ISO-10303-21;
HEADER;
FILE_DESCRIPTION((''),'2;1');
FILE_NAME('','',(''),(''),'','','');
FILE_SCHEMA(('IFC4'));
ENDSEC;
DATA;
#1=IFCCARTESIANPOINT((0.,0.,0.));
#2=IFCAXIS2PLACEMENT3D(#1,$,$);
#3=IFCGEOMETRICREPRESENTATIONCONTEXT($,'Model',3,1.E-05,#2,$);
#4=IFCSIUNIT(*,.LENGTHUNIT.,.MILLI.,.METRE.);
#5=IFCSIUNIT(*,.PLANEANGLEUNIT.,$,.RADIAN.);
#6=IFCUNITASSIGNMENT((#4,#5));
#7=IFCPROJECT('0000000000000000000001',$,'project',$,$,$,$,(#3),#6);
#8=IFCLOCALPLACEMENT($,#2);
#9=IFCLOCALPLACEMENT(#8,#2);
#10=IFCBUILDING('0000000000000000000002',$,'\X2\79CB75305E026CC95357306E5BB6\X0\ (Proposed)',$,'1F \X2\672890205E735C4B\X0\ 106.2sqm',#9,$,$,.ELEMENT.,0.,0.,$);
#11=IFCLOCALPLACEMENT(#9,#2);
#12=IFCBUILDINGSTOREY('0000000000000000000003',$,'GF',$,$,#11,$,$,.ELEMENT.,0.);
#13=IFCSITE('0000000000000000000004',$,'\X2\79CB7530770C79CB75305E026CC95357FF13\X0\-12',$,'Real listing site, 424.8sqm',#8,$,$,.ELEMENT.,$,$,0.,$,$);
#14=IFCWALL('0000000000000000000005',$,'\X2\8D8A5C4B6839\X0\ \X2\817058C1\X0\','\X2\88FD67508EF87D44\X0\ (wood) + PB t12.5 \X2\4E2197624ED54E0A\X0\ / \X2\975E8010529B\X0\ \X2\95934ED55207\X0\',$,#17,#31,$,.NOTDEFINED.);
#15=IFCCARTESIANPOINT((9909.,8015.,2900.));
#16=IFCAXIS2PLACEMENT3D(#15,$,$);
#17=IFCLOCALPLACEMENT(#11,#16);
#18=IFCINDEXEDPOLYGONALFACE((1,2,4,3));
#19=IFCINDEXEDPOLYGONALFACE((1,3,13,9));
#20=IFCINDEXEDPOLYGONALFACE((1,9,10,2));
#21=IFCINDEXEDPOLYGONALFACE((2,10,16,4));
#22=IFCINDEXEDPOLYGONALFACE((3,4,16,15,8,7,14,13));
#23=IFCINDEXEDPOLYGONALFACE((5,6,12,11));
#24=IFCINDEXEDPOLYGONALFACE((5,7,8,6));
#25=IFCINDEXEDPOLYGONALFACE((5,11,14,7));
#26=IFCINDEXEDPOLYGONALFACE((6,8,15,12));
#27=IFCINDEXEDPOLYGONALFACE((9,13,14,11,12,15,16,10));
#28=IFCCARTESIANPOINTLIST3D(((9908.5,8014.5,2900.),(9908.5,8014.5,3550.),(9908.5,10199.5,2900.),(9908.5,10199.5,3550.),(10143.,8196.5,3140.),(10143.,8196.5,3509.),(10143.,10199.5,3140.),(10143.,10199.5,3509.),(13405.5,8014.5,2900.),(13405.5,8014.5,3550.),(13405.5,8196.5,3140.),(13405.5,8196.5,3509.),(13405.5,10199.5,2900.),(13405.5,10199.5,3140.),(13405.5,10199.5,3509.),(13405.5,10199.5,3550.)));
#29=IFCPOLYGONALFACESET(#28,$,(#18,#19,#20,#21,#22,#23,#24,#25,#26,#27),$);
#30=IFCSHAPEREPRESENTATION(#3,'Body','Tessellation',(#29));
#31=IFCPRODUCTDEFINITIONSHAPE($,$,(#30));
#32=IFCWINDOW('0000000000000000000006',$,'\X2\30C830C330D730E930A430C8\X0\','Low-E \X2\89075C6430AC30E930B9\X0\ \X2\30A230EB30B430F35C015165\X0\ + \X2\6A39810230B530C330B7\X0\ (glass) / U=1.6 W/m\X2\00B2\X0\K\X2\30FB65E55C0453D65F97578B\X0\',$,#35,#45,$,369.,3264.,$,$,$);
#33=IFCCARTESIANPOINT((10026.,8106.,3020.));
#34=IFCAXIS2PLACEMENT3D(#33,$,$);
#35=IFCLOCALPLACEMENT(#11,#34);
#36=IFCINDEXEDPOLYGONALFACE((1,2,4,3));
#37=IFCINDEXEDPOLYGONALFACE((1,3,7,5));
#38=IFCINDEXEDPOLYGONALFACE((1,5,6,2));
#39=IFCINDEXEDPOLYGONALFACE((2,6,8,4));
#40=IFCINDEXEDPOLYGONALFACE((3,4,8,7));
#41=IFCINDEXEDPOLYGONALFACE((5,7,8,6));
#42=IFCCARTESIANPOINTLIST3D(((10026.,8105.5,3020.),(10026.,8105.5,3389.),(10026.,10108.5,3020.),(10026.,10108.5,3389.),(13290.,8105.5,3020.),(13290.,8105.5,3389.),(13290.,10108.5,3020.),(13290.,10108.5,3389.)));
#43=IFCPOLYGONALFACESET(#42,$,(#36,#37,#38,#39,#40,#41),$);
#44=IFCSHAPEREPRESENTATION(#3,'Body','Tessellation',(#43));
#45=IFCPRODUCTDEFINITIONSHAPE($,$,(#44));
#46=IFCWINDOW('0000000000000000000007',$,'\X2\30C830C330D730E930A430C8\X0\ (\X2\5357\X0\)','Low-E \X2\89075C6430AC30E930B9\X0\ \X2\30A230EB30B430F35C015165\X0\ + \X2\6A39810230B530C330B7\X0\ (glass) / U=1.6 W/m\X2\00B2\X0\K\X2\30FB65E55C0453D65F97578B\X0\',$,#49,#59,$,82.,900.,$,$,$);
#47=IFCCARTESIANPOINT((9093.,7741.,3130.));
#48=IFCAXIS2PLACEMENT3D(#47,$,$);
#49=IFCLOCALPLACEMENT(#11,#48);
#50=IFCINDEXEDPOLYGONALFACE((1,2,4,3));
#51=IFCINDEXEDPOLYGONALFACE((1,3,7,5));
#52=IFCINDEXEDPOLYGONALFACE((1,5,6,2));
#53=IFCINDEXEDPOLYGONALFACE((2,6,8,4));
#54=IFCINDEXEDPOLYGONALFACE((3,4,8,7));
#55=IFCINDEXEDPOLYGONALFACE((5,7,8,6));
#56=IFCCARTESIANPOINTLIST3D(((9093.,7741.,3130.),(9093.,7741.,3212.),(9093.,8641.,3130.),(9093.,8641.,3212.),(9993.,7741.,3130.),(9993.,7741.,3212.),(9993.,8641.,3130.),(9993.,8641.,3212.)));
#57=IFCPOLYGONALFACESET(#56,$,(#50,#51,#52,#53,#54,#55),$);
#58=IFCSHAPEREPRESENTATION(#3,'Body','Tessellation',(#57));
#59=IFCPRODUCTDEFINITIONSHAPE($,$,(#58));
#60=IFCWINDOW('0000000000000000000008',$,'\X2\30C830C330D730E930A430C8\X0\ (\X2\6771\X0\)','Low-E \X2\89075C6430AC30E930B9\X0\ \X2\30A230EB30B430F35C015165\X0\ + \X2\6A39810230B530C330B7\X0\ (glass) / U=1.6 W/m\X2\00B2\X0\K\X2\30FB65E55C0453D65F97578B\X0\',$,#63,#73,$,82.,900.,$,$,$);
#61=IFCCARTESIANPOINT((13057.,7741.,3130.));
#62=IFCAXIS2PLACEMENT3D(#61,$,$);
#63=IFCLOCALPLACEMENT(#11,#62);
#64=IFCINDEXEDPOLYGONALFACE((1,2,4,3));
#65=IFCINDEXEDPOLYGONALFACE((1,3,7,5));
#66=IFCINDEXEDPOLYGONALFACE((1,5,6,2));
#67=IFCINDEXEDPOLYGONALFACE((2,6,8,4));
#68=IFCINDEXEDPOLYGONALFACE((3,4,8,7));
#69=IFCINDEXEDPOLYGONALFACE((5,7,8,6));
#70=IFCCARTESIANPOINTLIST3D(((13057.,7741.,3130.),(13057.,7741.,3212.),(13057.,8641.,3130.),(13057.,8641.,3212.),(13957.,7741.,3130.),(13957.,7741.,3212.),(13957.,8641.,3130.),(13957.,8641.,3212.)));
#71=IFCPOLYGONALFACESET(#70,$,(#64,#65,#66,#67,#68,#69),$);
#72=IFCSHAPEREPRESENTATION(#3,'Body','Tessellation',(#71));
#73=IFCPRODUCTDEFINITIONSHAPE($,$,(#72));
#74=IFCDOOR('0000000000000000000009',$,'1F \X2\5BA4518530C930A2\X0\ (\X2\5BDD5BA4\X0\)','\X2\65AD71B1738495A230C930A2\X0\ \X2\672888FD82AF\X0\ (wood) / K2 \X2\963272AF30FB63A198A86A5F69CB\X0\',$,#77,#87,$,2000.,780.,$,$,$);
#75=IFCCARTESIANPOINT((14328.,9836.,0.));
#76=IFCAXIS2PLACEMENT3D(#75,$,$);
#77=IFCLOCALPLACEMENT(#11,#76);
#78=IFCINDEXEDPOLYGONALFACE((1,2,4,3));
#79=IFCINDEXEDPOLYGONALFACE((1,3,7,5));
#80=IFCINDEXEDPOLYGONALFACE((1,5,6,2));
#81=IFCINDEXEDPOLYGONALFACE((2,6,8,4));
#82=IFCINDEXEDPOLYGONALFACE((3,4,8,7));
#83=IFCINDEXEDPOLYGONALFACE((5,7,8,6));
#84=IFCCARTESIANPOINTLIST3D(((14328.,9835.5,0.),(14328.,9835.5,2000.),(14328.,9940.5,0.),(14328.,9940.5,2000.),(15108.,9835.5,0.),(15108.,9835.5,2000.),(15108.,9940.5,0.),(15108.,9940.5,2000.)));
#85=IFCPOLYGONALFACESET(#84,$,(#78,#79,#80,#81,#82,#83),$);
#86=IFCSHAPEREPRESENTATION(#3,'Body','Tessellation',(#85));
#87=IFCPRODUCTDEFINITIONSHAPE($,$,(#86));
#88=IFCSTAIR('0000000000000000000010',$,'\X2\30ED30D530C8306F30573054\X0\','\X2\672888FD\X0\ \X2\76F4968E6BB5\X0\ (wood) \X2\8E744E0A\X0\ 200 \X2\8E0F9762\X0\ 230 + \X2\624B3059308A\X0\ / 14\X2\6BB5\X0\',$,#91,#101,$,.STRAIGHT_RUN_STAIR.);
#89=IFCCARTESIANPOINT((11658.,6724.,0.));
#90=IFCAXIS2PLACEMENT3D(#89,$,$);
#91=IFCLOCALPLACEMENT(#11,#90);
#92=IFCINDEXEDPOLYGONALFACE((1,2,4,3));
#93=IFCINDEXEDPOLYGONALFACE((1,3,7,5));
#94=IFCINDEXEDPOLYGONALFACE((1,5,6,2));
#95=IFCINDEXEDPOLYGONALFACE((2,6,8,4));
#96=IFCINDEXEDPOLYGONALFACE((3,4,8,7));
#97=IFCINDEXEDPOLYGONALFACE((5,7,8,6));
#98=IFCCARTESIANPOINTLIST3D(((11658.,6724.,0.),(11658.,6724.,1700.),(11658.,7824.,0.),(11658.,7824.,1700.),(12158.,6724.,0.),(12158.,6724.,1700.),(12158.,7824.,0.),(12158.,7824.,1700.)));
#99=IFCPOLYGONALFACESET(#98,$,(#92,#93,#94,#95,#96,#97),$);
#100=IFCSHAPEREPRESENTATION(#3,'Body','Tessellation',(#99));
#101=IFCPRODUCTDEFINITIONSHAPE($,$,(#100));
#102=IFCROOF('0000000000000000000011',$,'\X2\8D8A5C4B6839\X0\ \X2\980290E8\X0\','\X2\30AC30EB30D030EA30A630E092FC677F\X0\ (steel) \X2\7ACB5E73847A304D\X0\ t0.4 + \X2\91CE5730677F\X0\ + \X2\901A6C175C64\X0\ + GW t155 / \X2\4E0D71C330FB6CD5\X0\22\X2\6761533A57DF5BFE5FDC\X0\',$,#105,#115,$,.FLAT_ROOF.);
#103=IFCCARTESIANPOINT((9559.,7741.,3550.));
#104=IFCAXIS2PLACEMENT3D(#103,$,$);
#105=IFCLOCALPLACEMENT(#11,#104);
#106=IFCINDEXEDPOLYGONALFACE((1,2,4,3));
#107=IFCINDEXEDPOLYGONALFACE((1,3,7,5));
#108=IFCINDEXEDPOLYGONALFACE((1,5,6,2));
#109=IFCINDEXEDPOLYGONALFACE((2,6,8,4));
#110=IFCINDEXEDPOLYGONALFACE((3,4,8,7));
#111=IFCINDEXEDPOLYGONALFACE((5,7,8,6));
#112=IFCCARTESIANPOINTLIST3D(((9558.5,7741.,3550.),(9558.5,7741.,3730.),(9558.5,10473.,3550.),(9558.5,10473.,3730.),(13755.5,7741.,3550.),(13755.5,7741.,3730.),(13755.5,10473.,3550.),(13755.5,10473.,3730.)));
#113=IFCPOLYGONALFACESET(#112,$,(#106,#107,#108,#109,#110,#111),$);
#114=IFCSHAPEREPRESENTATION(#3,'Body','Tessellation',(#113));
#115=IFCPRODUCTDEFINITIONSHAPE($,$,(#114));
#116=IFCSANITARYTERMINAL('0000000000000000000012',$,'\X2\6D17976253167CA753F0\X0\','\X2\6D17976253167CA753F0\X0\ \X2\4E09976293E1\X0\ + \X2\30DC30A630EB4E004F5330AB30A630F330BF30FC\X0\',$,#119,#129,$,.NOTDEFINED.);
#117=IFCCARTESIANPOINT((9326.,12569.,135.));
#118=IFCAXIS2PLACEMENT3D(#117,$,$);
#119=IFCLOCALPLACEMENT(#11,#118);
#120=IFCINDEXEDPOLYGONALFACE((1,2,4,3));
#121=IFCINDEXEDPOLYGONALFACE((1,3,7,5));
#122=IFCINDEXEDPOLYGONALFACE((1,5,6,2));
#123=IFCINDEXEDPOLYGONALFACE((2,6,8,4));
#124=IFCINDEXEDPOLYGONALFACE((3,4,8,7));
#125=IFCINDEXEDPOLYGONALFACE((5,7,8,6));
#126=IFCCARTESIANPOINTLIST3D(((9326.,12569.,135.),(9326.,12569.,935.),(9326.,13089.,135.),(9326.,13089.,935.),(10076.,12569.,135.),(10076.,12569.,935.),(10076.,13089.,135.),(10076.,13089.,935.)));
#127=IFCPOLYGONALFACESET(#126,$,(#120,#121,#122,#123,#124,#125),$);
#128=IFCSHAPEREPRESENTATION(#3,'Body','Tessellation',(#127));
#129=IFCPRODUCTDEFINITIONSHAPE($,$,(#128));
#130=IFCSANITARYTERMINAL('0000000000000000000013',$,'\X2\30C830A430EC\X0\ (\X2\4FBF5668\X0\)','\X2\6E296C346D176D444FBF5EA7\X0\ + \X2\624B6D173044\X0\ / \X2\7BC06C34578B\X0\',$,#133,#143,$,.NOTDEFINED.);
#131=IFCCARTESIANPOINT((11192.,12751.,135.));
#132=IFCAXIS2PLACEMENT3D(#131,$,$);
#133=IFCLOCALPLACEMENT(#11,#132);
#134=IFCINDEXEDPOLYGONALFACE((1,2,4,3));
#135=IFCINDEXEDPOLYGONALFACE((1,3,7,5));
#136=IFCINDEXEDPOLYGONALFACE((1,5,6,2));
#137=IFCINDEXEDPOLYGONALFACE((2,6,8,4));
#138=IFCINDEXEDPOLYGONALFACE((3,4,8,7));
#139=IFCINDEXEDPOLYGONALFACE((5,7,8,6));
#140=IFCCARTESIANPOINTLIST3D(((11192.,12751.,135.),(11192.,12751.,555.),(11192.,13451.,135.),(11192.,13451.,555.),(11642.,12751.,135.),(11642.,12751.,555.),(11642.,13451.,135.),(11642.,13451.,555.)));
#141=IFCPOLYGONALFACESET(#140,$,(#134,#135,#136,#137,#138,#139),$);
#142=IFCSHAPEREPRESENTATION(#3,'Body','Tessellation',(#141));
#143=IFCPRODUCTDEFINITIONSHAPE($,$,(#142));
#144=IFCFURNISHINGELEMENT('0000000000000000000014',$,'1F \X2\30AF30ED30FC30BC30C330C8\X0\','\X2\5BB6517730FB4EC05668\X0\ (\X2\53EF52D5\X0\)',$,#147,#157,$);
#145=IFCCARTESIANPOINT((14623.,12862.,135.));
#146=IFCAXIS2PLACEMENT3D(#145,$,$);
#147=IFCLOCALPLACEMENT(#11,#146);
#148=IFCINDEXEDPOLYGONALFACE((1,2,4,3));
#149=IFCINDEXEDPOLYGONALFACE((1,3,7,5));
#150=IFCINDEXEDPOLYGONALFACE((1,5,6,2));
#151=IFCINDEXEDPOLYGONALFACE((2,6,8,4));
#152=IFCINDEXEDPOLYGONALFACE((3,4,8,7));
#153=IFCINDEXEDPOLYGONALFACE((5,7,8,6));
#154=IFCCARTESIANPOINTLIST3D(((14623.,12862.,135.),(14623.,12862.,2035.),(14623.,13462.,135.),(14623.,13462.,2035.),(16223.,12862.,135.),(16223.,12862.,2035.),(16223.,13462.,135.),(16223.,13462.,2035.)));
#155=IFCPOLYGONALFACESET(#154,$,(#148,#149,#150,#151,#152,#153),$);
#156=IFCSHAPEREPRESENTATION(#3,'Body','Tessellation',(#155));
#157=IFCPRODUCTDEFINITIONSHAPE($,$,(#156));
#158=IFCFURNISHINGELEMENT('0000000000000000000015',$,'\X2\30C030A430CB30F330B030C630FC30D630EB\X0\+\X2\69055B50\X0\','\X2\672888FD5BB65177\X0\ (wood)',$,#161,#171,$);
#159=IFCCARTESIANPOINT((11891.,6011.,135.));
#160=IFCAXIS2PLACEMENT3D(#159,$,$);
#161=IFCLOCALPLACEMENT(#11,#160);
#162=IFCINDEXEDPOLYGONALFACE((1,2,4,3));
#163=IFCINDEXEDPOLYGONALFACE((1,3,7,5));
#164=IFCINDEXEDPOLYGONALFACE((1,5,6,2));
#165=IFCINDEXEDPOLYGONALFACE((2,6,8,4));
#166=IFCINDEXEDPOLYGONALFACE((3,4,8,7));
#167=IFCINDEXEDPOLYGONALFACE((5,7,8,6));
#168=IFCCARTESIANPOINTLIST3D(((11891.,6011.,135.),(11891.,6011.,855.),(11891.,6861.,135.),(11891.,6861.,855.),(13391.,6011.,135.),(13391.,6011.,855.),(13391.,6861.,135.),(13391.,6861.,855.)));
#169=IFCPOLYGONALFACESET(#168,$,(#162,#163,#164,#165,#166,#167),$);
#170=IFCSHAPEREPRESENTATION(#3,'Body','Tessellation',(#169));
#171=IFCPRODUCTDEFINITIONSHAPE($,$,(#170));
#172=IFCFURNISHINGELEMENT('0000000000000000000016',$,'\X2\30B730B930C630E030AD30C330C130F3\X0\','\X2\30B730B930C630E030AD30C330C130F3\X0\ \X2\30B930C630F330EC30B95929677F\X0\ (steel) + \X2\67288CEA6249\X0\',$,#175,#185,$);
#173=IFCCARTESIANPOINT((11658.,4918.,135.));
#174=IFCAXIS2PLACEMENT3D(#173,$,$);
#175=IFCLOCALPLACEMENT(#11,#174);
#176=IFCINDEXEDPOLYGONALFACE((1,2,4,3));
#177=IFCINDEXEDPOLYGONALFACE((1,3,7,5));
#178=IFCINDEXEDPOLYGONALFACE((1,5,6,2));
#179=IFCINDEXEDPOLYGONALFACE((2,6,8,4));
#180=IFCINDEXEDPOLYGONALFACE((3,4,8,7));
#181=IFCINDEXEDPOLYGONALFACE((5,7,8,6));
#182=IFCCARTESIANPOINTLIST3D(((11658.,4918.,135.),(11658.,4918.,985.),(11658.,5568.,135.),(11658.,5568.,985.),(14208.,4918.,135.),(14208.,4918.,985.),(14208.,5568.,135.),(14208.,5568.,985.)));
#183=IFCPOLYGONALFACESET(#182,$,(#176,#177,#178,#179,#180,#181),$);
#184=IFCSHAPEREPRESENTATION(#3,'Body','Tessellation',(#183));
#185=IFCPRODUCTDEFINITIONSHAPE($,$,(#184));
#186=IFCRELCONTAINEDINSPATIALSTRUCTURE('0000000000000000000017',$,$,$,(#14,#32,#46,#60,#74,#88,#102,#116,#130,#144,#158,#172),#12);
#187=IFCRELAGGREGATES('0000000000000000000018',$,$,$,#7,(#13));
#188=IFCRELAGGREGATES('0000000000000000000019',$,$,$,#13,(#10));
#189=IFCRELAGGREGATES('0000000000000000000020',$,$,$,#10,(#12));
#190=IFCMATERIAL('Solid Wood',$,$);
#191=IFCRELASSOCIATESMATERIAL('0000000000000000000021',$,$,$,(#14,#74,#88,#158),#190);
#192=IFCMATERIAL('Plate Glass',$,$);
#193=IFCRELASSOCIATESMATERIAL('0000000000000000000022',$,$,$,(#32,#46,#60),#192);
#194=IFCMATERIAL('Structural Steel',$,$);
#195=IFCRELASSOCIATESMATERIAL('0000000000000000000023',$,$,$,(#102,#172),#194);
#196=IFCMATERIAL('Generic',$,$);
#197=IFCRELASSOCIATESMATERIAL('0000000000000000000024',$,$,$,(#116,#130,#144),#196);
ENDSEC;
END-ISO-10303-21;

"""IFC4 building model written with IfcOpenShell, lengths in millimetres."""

from ifc_helpers import new_model, si_unit, frame, frame_2d, origin, place, context, project, spatial, rectangle, extrude, material, element, fill, save


model = new_model("IFC4")

# Units and contexts
model_context = context("Model", 3, precision=1e-05, world=origin())
ifc_project = project(units=[si_unit("LENGTHUNIT", "METRE", prefix="MILLI"), si_unit("PLANEANGLEUNIT", "RADIAN")], contexts=[model_context])

# Site, building, storey
site_placement = place(None, origin())
site = spatial("IfcSite", under=ifc_project, at=site_placement, Name="秋田県秋田市泉南３-12", ObjectType="Real listing site, 424.8sqm", CompositionType="ELEMENT", RefElevation=0.0)
building_placement = place(site_placement, origin())
building = spatial("IfcBuilding", under=site, at=building_placement, Name="秋田市泉南の家 (Proposed)", ObjectType="1F 木造平屋 106.2sqm", CompositionType="ELEMENT", ElevationOfRefHeight=0.0, ElevationOfTerrain=0.0)
storey_placement = place(building_placement, origin())
storey = spatial("IfcBuildingStorey", under=building, at=storey_placement, Name="GF", CompositionType="ELEMENT", Elevation=0.0)

# Shared definitions
ifc_material_1 = material(Name="Solid Wood")
ifc_material_2 = material(Name="Plate Glass")

# Wall, openings, windows
wall_1_placement = place(storey_placement, frame((9909.0, 8015.0, 2900.0)))
wall_1 = element("IfcWall", 1, at=wall_1_placement, inside=storey, material=ifc_material_1, Name="越屋根 腰壁", Description="製材軸組 (wood) + PB t12.5 両面仕上 / 非耐力 間仕切", PredefinedType="NOTDEFINED", context=model_context, shape_type="SweptSolid", body=[
    extrude(rectangle(XDim=3497.0, YDim=2185.0, at=frame_2d((1748.0, 1092.0))), frame((9909.0, 8015.0, 2900.0)), (0.0, 0.0, 1.0), 650.0),
])
opening_1_placement = place(storey_placement, frame((10026.0, 8106.0, 3020.0)))
opening_1 = element("IfcOpeningElement", 2, at=opening_1_placement, cuts=wall_1, PredefinedType="NOTDEFINED", context=model_context, shape_type="SweptSolid", body=[
    extrude(rectangle(XDim=3264.0, YDim=2003.0, at=frame_2d((1632.0, 1001.0))), frame((10026.0, 8106.0, 3020.0)), (0.0, 0.0, 1.0), 369.0),
])
opening_2_placement = place(storey_placement, frame((9093.0, 7741.0, 3130.0)))
opening_2 = element("IfcOpeningElement", 3, at=opening_2_placement, cuts=wall_1, PredefinedType="NOTDEFINED", context=model_context, shape_type="SweptSolid", body=[
    extrude(rectangle(XDim=900.0, YDim=900.0, at=frame_2d((450.0, 450.0))), frame((9093.0, 7741.0, 3130.0)), (0.0, 0.0, 1.0), 82.0),
])
opening_3_placement = place(storey_placement, frame((13057.0, 7741.0, 3130.0)))
opening_3 = element("IfcOpeningElement", 4, at=opening_3_placement, cuts=wall_1, PredefinedType="NOTDEFINED", context=model_context, shape_type="SweptSolid", body=[
    extrude(rectangle(XDim=900.0, YDim=900.0, at=frame_2d((450.0, 450.0))), frame((13057.0, 7741.0, 3130.0)), (0.0, 0.0, 1.0), 82.0),
])
window_1_placement = place(storey_placement, frame((10026.0, 8106.0, 3020.0)))
window_1 = element("IfcWindow", 5, at=window_1_placement, inside=storey, material=ifc_material_2, Name="トップライト", Description="Low-E 複層ガラス アルゴン封入 + 樹脂サッシ (glass) / U=1.6 W/m²K・日射取得型", OverallHeight=369.0, OverallWidth=3264.0, context=model_context, shape_type="SweptSolid", body=[
    extrude(rectangle(XDim=3264.0, YDim=2003.0, at=frame_2d((1632.0, 1001.0))), frame((10026.0, 8106.0, 3020.0)), (0.0, 0.0, 1.0), 369.0),
])
fill(opening_1, window_1)
window_2_placement = place(storey_placement, frame((9093.0, 7741.0, 3130.0)))
window_2 = element("IfcWindow", 6, at=window_2_placement, inside=storey, material=ifc_material_2, Name="トップライト (南)", Description="Low-E 複層ガラス アルゴン封入 + 樹脂サッシ (glass) / U=1.6 W/m²K・日射取得型", OverallHeight=82.0, OverallWidth=900.0, context=model_context, shape_type="SweptSolid", body=[
    extrude(rectangle(XDim=900.0, YDim=900.0, at=frame_2d((450.0, 450.0))), frame((9093.0, 7741.0, 3130.0)), (0.0, 0.0, 1.0), 82.0),
])
fill(opening_2, window_2)
window_3_placement = place(storey_placement, frame((13057.0, 7741.0, 3130.0)))
window_3 = element("IfcWindow", 7, at=window_3_placement, inside=storey, material=ifc_material_2, Name="トップライト (東)", Description="Low-E 複層ガラス アルゴン封入 + 樹脂サッシ (glass) / U=1.6 W/m²K・日射取得型", OverallHeight=82.0, OverallWidth=900.0, context=model_context, shape_type="SweptSolid", body=[
    extrude(rectangle(XDim=900.0, YDim=900.0, at=frame_2d((450.0, 450.0))), frame((13057.0, 7741.0, 3130.0)), (0.0, 0.0, 1.0), 82.0),
])
fill(opening_3, window_3)

# Door
door_placement = place(storey_placement, frame((14328.0, 9836.0, 0.0)))
element("IfcDoor", 8, at=door_placement, inside=storey, material=ifc_material_1, Name="1F 室内ドア (寝室)", Description="断熱玄関ドア 木製芯 (wood) / K2 防犯・採風機構", OverallHeight=2000.0, OverallWidth=780.0, context=model_context, shape_type="SweptSolid", body=[
    extrude(rectangle(XDim=780.0, YDim=105.0, at=frame_2d((390.0, 52.0))), frame((14328.0, 9836.0, 0.0)), (0.0, 0.0, 1.0), 2000.0),
])

# Stair
stair_placement = place(storey_placement, frame((11658.0, 6724.0, 0.0)))
element("IfcStair", 9, at=stair_placement, inside=storey, material=ifc_material_1, Name="ロフトはしご", Description="木製 直階段 (wood) 蹴上 200 踏面 230 + 手すり / 14段", PredefinedType="STRAIGHT_RUN_STAIR", context=model_context, shape_type="SweptSolid", body=[
    extrude(rectangle(XDim=500.0, YDim=1100.0, at=frame_2d((250.0, 550.0))), frame((11658.0, 6724.0, 0.0)), (0.0, 0.0, 1.0), 1700.0),
])

# Roof
ifc_material_3 = material(Name="Structural Steel")
roof_placement = place(storey_placement, frame((9559.0, 7741.0, 3550.0)))
element("IfcRoof", 10, at=roof_placement, inside=storey, material=ifc_material_3, Name="越屋根 頂部", Description="ガルバリウム鋼板 (steel) 立平葺き t0.4 + 野地板 + 通気層 + GW t155 / 不燃・法22条区域対応", PredefinedType="FLAT_ROOF", context=model_context, shape_type="SweptSolid", body=[
    extrude(rectangle(XDim=4197.0, YDim=2732.0, at=frame_2d((2098.0, 1366.0))), frame((9559.0, 7741.0, 3550.0)), (0.0, 0.0, 1.0), 180.0),
])

# Sanitary terminals
ifc_material_4 = material(Name="Generic")
sanitary_terminal_1_placement = place(storey_placement, frame((9326.0, 12569.0, 135.0)))
element("IfcSanitaryTerminal", 11, at=sanitary_terminal_1_placement, inside=storey, material=ifc_material_4, Name="洗面化粧台", Description="洗面化粧台 三面鏡 + ボウル一体カウンター", PredefinedType="NOTDEFINED", context=model_context, shape_type="SweptSolid", body=[
    extrude(rectangle(XDim=750.0, YDim=520.0, at=frame_2d((375.0, 260.0))), frame((9326.0, 12569.0, 135.0)), (0.0, 0.0, 1.0), 800.0),
])
sanitary_terminal_2_placement = place(storey_placement, frame((11192.0, 12751.0, 135.0)))
element("IfcSanitaryTerminal", 12, at=sanitary_terminal_2_placement, inside=storey, material=ifc_material_4, Name="トイレ (便器)", Description="温水洗浄便座 + 手洗い / 節水型", PredefinedType="NOTDEFINED", context=model_context, shape_type="SweptSolid", body=[
    extrude(rectangle(XDim=450.0, YDim=700.0, at=frame_2d((225.0, 350.0))), frame((11192.0, 12751.0, 135.0)), (0.0, 0.0, 1.0), 420.0),
])

# Furnishing elements
furnishing_1_placement = place(storey_placement, frame((14623.0, 12862.0, 135.0)))
element("IfcFurnishingElement", 13, at=furnishing_1_placement, inside=storey, material=ifc_material_4, Name="1F クローゼット", Description="家具・什器 (可動)", context=model_context, shape_type="SweptSolid", body=[
    extrude(rectangle(XDim=1600.0, YDim=600.0, at=frame_2d((800.0, 300.0))), frame((14623.0, 12862.0, 135.0)), (0.0, 0.0, 1.0), 1900.0),
])
furnishing_2_placement = place(storey_placement, frame((11891.0, 6011.0, 135.0)))
element("IfcFurnishingElement", 14, at=furnishing_2_placement, inside=storey, material=ifc_material_1, Name="ダイニングテーブル+椅子", Description="木製家具 (wood)", context=model_context, shape_type="SweptSolid", body=[
    extrude(rectangle(XDim=1500.0, YDim=850.0, at=frame_2d((750.0, 425.0))), frame((11891.0, 6011.0, 135.0)), (0.0, 0.0, 1.0), 720.0),
])
furnishing_3_placement = place(storey_placement, frame((11658.0, 4918.0, 135.0)))
element("IfcFurnishingElement", 15, at=furnishing_3_placement, inside=storey, material=ifc_material_3, Name="システムキッチン", Description="システムキッチン ステンレス天板 (steel) + 木質扉", context=model_context, shape_type="SweptSolid", body=[
    extrude(rectangle(XDim=2550.0, YDim=650.0, at=frame_2d((1275.0, 325.0))), frame((11658.0, 4918.0, 135.0)), (0.0, 0.0, 1.0), 850.0),
])

save(model, "model.ifc")
